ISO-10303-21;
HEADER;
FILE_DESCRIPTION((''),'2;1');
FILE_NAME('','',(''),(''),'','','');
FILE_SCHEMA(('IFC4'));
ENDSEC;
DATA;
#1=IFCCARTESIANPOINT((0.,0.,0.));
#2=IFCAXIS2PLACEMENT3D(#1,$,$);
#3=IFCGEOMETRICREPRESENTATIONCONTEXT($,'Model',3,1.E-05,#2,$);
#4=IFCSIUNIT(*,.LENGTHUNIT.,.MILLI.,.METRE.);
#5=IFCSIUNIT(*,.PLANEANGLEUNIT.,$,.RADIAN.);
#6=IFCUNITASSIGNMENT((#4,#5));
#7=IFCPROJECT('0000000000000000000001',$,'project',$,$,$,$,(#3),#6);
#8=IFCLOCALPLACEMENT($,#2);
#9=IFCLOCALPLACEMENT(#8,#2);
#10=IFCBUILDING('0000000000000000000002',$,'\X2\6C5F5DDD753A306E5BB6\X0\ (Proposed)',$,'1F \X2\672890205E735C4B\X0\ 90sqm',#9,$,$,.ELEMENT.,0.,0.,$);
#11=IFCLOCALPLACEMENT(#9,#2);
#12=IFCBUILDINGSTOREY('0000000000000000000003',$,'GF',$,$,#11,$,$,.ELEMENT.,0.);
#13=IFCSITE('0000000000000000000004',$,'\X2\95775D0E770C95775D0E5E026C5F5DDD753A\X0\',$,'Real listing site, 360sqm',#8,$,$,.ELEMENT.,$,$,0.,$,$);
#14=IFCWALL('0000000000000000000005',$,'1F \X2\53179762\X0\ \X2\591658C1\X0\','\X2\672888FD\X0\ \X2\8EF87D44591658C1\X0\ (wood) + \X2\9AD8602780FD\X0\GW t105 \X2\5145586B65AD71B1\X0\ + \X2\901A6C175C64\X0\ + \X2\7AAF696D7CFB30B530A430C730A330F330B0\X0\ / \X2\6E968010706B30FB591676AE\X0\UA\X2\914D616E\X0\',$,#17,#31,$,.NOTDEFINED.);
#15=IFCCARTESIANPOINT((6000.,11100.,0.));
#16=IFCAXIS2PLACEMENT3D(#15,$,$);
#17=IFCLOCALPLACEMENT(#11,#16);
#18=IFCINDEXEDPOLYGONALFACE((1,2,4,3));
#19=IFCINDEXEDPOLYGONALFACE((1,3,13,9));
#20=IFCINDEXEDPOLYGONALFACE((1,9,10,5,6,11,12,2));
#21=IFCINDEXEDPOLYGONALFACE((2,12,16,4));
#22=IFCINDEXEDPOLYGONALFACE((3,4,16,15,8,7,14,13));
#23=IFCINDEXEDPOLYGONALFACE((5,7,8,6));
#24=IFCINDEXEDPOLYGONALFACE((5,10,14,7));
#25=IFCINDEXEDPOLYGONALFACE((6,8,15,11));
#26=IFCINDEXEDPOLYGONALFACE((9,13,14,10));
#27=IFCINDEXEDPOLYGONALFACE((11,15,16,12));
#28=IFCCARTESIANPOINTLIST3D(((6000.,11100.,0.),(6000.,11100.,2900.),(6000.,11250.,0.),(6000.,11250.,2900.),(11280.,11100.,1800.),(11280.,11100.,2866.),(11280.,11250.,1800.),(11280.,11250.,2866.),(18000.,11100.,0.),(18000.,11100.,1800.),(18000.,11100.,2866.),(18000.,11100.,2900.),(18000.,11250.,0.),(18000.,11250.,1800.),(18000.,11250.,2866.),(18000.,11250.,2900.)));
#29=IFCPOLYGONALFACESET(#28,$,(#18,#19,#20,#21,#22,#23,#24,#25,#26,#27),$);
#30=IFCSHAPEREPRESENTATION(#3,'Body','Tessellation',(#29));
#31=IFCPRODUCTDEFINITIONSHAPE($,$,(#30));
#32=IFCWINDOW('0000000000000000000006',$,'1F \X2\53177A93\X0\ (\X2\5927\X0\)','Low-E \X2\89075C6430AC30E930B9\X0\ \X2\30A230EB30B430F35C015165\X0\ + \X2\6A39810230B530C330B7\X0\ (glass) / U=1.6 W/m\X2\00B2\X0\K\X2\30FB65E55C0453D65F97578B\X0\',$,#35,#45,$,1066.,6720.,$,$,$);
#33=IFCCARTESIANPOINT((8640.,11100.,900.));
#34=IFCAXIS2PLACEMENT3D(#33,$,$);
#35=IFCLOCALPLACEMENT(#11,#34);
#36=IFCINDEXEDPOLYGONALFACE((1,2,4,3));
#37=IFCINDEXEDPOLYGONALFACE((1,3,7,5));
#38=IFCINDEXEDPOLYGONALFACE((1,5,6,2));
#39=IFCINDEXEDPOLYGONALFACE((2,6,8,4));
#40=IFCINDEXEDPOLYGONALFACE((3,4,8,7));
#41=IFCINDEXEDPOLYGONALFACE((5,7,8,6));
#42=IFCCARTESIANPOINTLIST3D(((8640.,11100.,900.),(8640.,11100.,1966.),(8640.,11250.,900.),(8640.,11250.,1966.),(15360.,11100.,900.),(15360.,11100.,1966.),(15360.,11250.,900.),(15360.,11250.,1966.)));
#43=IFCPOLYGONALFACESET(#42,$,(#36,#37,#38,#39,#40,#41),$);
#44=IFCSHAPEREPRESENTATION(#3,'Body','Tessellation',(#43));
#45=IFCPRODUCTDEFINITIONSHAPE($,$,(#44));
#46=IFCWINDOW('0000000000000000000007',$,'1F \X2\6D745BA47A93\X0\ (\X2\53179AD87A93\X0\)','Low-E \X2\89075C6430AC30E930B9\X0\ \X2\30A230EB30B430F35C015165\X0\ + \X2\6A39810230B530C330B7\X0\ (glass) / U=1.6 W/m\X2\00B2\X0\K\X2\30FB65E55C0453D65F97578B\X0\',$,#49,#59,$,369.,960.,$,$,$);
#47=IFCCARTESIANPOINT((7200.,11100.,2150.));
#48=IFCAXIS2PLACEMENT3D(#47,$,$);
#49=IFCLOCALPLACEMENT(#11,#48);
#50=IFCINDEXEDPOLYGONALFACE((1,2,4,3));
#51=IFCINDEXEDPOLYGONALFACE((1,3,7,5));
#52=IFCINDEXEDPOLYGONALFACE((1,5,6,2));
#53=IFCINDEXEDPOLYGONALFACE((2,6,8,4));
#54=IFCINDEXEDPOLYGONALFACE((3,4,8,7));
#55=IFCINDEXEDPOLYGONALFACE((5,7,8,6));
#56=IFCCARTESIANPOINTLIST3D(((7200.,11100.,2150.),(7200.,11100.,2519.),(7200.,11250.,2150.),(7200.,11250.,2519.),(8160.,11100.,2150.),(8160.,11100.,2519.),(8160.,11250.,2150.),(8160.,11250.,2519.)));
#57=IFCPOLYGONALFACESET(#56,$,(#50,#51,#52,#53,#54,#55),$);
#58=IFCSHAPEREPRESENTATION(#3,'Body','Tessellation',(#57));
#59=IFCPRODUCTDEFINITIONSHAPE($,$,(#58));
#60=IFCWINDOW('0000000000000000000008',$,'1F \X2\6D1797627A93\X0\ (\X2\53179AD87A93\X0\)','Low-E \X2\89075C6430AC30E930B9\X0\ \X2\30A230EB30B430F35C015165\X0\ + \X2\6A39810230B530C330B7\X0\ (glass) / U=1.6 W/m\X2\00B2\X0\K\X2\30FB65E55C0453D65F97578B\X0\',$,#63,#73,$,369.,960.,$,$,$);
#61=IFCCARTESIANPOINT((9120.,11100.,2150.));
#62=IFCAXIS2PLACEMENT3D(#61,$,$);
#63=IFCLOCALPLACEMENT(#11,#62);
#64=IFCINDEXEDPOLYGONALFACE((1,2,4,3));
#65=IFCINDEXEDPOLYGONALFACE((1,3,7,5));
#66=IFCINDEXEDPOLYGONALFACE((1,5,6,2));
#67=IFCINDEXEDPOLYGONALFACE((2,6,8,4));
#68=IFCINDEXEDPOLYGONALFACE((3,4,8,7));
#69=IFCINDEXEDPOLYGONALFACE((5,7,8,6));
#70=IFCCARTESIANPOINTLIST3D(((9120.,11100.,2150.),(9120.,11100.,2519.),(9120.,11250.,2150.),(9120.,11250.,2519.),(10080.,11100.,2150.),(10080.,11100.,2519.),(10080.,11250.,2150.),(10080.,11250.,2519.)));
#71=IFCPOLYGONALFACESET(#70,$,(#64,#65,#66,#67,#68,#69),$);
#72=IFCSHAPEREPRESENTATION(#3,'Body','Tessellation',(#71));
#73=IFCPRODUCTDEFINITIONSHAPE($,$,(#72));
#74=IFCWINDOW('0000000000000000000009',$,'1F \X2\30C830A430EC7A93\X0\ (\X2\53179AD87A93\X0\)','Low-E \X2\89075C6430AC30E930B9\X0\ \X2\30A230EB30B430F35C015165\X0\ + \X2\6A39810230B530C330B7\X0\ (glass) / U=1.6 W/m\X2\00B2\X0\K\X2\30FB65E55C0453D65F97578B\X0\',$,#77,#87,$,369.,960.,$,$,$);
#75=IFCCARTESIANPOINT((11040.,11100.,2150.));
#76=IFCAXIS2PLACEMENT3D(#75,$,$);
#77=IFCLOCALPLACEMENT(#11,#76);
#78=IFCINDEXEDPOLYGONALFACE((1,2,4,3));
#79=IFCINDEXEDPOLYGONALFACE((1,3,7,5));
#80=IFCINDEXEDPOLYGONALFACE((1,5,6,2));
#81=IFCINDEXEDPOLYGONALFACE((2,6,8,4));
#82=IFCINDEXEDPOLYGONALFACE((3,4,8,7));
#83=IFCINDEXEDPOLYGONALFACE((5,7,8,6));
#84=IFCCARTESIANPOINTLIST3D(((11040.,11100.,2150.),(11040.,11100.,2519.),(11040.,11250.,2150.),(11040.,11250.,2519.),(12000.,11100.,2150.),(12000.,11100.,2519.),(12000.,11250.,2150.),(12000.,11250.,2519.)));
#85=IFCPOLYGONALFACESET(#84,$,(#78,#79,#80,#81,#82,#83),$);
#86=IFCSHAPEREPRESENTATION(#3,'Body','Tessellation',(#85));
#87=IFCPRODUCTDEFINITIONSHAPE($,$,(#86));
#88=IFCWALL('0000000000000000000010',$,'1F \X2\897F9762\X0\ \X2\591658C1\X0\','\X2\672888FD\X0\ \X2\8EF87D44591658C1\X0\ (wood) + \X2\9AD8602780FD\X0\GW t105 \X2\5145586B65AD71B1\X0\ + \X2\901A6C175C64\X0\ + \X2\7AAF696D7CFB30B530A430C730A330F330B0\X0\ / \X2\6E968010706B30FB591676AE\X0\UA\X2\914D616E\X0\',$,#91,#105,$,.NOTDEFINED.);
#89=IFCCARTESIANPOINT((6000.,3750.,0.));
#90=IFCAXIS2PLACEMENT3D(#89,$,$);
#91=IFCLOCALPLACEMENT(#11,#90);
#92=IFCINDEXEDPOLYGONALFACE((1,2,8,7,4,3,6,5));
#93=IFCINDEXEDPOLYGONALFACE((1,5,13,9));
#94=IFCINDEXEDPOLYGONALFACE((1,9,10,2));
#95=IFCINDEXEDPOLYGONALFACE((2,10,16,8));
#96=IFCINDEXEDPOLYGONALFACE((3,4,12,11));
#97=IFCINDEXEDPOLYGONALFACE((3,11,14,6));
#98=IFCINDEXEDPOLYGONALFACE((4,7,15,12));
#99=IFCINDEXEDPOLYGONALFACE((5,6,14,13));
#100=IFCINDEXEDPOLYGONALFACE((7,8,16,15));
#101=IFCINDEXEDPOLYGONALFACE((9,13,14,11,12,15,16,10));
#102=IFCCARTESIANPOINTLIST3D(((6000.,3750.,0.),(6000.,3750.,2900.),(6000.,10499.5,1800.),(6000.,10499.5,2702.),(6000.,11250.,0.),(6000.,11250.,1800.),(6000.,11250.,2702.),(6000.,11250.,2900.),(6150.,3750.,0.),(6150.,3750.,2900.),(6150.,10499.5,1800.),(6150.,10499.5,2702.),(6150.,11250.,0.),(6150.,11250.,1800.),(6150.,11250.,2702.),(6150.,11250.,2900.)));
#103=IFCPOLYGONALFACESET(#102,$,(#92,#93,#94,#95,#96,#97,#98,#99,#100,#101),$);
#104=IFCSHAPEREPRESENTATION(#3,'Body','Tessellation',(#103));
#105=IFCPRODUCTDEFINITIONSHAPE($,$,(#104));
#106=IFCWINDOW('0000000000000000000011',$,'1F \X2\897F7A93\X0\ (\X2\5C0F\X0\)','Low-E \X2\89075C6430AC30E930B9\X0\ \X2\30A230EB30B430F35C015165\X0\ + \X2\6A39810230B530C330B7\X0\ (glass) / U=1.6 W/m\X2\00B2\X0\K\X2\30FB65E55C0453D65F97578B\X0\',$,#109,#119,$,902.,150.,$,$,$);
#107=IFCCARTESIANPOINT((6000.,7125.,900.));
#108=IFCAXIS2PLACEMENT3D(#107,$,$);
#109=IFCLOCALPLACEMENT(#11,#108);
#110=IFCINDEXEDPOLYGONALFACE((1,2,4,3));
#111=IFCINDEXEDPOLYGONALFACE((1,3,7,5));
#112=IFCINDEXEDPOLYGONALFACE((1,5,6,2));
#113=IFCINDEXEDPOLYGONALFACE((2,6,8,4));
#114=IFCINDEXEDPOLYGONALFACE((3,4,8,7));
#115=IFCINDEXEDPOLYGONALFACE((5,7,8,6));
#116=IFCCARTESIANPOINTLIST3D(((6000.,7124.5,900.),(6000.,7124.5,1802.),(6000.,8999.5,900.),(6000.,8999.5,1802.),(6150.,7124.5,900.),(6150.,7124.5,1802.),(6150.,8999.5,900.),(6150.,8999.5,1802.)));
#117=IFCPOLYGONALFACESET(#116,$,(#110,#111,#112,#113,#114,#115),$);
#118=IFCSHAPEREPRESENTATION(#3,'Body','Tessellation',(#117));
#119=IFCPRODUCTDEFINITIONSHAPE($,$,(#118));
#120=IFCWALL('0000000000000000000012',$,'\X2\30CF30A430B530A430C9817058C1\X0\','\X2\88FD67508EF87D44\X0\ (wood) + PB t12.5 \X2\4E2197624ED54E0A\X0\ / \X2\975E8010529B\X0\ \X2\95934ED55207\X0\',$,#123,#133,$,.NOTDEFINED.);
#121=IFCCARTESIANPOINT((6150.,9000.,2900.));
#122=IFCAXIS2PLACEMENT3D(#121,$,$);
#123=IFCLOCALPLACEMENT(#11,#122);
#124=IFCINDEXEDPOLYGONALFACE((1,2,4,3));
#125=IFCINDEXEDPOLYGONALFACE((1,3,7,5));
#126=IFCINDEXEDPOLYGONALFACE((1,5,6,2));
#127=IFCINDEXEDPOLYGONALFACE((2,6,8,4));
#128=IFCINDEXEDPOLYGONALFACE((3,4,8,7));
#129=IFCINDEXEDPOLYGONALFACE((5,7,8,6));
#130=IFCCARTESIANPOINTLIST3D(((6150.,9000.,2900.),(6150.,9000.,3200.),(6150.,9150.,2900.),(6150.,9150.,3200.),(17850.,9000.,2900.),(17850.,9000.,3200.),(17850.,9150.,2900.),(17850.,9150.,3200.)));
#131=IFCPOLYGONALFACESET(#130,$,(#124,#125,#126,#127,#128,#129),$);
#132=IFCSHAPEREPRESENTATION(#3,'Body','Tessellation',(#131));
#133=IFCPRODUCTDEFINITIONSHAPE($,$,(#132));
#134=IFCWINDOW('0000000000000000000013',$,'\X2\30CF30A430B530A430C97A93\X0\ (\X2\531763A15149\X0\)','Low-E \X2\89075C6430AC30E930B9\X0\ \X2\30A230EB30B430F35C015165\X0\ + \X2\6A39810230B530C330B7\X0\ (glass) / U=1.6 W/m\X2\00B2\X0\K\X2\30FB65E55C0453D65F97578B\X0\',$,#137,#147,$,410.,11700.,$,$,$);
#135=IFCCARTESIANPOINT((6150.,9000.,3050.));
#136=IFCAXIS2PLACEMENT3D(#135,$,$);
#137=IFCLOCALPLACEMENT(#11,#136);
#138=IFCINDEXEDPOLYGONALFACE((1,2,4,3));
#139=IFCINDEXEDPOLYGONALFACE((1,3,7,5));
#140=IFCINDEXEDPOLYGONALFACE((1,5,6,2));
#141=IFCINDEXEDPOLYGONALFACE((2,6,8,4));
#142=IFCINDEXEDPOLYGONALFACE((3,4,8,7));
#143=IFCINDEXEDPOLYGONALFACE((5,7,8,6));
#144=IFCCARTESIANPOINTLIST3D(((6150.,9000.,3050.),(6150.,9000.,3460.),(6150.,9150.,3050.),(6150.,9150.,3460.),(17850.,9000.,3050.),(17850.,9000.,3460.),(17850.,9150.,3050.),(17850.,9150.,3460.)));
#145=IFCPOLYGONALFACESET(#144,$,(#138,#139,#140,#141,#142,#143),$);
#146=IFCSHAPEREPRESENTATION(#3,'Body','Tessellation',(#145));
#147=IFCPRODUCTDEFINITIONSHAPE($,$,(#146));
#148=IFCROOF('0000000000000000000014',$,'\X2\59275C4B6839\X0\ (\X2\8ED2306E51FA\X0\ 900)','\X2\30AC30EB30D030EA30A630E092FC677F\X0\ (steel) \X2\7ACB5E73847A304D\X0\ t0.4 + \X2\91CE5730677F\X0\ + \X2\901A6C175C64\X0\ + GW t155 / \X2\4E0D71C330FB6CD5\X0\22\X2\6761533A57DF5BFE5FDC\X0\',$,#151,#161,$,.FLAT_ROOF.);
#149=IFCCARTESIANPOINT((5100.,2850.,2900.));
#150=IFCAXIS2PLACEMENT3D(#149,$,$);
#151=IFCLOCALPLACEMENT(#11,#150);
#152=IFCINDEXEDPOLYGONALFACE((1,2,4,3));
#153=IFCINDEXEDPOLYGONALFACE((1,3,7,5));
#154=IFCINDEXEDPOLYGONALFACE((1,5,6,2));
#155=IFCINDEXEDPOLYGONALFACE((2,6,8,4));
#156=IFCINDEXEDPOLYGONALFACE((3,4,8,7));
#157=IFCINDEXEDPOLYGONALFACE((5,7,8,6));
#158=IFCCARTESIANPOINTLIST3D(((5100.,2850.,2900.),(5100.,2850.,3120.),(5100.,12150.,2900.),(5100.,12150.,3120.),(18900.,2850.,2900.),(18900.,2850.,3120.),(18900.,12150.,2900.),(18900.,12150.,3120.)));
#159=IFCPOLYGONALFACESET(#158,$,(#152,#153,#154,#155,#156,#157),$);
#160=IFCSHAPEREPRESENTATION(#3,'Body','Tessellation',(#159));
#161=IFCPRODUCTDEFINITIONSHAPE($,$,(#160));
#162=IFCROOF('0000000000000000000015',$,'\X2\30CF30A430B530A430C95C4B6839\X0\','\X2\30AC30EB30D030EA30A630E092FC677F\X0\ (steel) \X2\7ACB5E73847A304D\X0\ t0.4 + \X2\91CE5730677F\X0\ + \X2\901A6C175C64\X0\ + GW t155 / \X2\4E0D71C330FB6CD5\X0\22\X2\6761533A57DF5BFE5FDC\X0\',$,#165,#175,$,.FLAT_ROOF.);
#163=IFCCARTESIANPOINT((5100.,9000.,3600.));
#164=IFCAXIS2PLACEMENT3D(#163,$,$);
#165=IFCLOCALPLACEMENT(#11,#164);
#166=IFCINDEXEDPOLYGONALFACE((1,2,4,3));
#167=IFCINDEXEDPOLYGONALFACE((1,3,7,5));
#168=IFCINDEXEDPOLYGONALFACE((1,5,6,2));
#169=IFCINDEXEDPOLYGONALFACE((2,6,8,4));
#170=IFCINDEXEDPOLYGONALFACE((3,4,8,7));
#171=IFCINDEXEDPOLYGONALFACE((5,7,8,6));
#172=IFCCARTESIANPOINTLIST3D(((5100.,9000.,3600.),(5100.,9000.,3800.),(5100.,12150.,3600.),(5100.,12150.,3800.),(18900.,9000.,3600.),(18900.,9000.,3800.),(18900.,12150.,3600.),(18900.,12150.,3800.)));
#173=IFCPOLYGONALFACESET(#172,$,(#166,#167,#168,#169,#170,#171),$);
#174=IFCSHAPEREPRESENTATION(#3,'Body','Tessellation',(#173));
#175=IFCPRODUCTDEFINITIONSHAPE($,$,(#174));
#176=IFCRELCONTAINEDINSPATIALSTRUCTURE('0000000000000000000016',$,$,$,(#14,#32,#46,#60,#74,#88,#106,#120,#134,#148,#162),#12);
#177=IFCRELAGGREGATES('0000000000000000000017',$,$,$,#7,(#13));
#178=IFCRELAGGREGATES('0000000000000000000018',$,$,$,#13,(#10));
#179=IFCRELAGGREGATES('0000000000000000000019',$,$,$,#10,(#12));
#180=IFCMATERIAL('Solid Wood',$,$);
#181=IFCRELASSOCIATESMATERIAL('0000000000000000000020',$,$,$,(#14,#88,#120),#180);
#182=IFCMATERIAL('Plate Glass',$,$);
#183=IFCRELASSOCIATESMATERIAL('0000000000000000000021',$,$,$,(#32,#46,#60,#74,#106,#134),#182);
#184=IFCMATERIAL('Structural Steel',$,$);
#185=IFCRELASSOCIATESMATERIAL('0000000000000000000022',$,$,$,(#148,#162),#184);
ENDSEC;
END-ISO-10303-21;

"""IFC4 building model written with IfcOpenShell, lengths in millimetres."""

from ifc_helpers import new_model, si_unit, frame, frame_2d, origin, place, context, project, spatial, rectangle, extrude, material, element, fill, save


model = new_model("IFC4")

# Units and contexts
model_context = context("Model", 3, precision=1e-05, world=origin())
ifc_project = project(units=[si_unit("LENGTHUNIT", "METRE", prefix="MILLI"), si_unit("PLANEANGLEUNIT", "RADIAN")], contexts=[model_context])

# Site, building, storey
site_placement = place(None, origin())
site = spatial("IfcSite", under=ifc_project, at=site_placement, Name="長崎県長崎市江川町", ObjectType="Real listing site, 360sqm", CompositionType="ELEMENT", RefElevation=0.0)
building_placement = place(site_placement, origin())
building = spatial("IfcBuilding", under=site, at=building_placement, Name="江川町の家 (Proposed)", ObjectType="1F 木造平屋 90sqm", CompositionType="ELEMENT", ElevationOfRefHeight=0.0, ElevationOfTerrain=0.0)
storey_placement = place(building_placement, origin())
storey = spatial("IfcBuildingStorey", under=building, at=storey_placement, Name="GF", CompositionType="ELEMENT", Elevation=0.0)

# Shared definitions
ifc_material_1 = material(Name="Solid Wood")

# Shared definitions
ifc_material_2 = material(Name="Plate Glass")

# Wall, openings, windows
wall_1_placement = place(storey_placement, frame((6000.0, 11100.0, 0.0)))
wall_1 = element("IfcWall", 1, at=wall_1_placement, inside=storey, material=ifc_material_1, Name="1F 北面 外壁", Description="木製 軸組外壁 (wood) + 高性能GW t105 充填断熱 + 通気層 + 窯業系サイディング / 準耐火・外皮UA配慮", PredefinedType="NOTDEFINED", context=model_context, shape_type="SweptSolid", body=[
    extrude(rectangle(XDim=12000.0, YDim=150.0, at=frame_2d((6000.0, 75.0))), frame((6000.0, 11100.0, 0.0)), (0.0, 0.0, 1.0), 2900.0),
])
opening_1_placement = place(storey_placement, frame((8640.0, 11100.0, 900.0)))
opening_1 = element("IfcOpeningElement", 2, at=opening_1_placement, cuts=wall_1, PredefinedType="NOTDEFINED", context=model_context, shape_type="SweptSolid", body=[
    extrude(rectangle(XDim=6720.0, YDim=150.0, at=frame_2d((3360.0, 75.0))), frame((8640.0, 11100.0, 900.0)), (0.0, 0.0, 1.0), 1066.0),
])
opening_2_placement = place(storey_placement, frame((7200.0, 11100.0, 2150.0)))
opening_2 = element("IfcOpeningElement", 3, at=opening_2_placement, cuts=wall_1, PredefinedType="NOTDEFINED", context=model_context, shape_type="SweptSolid", body=[
    extrude(rectangle(XDim=960.0, YDim=150.0, at=frame_2d((480.0, 75.0))), frame((7200.0, 11100.0, 2150.0)), (0.0, 0.0, 1.0), 369.0),
])
opening_3_placement = place(storey_placement, frame((9120.0, 11100.0, 2150.0)))
opening_3 = element("IfcOpeningElement", 4, at=opening_3_placement, cuts=wall_1, PredefinedType="NOTDEFINED", context=model_context, shape_type="SweptSolid", body=[
    extrude(rectangle(XDim=960.0, YDim=150.0, at=frame_2d((480.0, 75.0))), frame((9120.0, 11100.0, 2150.0)), (0.0, 0.0, 1.0), 369.0),
])
opening_4_placement = place(storey_placement, frame((11040.0, 11100.0, 2150.0)))
opening_4 = element("IfcOpeningElement", 5, at=opening_4_placement, cuts=wall_1, PredefinedType="NOTDEFINED", context=model_context, shape_type="SweptSolid", body=[
    extrude(rectangle(XDim=960.0, YDim=150.0, at=frame_2d((480.0, 75.0))), frame((11040.0, 11100.0, 2150.0)), (0.0, 0.0, 1.0), 369.0),
])
window_1_placement = place(storey_placement, frame((8640.0, 11100.0, 900.0)))
window_1 = element("IfcWindow", 6, at=window_1_placement, inside=storey, material=ifc_material_2, Name="1F 北窓 (大)", Description="Low-E 複層ガラス アルゴン封入 + 樹脂サッシ (glass) / U=1.6 W/m²K・日射取得型", OverallHeight=1066.0, OverallWidth=6720.0, context=model_context, shape_type="SweptSolid", body=[
    extrude(rectangle(XDim=6720.0, YDim=150.0, at=frame_2d((3360.0, 75.0))), frame((8640.0, 11100.0, 900.0)), (0.0, 0.0, 1.0), 1066.0),
])
fill(opening_1, window_1)
window_2_placement = place(storey_placement, frame((7200.0, 11100.0, 2150.0)))
window_2 = element("IfcWindow", 7, at=window_2_placement, inside=storey, material=ifc_material_2, Name="1F 浴室窓 (北高窓)", Description="Low-E 複層ガラス アルゴン封入 + 樹脂サッシ (glass) / U=1.6 W/m²K・日射取得型", OverallHeight=369.0, OverallWidth=960.0, context=model_context, shape_type="SweptSolid", body=[
    extrude(rectangle(XDim=960.0, YDim=150.0, at=frame_2d((480.0, 75.0))), frame((7200.0, 11100.0, 2150.0)), (0.0, 0.0, 1.0), 369.0),
])
fill(opening_2, window_2)
window_3_placement = place(storey_placement, frame((9120.0, 11100.0, 2150.0)))
window_3 = element("IfcWindow", 8, at=window_3_placement, inside=storey, material=ifc_material_2, Name="1F 洗面窓 (北高窓)", Description="Low-E 複層ガラス アルゴン封入 + 樹脂サッシ (glass) / U=1.6 W/m²K・日射取得型", OverallHeight=369.0, OverallWidth=960.0, context=model_context, shape_type="SweptSolid", body=[
    extrude(rectangle(XDim=960.0, YDim=150.0, at=frame_2d((480.0, 75.0))), frame((9120.0, 11100.0, 2150.0)), (0.0, 0.0, 1.0), 369.0),
])
fill(opening_3, window_3)
window_4_placement = place(storey_placement, frame((11040.0, 11100.0, 2150.0)))
window_4 = element("IfcWindow", 9, at=window_4_placement, inside=storey, material=ifc_material_2, Name="1F トイレ窓 (北高窓)", Description="Low-E 複層ガラス アルゴン封入 + 樹脂サッシ (glass) / U=1.6 W/m²K・日射取得型", OverallHeight=369.0, OverallWidth=960.0, context=model_context, shape_type="SweptSolid", body=[
    extrude(rectangle(XDim=960.0, YDim=150.0, at=frame_2d((480.0, 75.0))), frame((11040.0, 11100.0, 2150.0)), (0.0, 0.0, 1.0), 369.0),
])
fill(opening_4, window_4)

# Wall, opening, window
wall_2_placement = place(storey_placement, frame((6000.0, 3750.0, 0.0)))
wall_2 = element("IfcWall", 10, at=wall_2_placement, inside=storey, material=ifc_material_1, Name="1F 西面 外壁", Description="木製 軸組外壁 (wood) + 高性能GW t105 充填断熱 + 通気層 + 窯業系サイディング / 準耐火・外皮UA配慮", PredefinedType="NOTDEFINED", context=model_context, shape_type="SweptSolid", body=[
    extrude(rectangle(XDim=150.0, YDim=7500.0, at=frame_2d((75.0, 3750.0))), frame((6000.0, 3750.0, 0.0)), (0.0, 0.0, 1.0), 2900.0),
])
opening_5_placement = place(storey_placement, frame((6000.0, 7125.0, 900.0)))
opening_5 = element("IfcOpeningElement", 11, at=opening_5_placement, cuts=wall_2, PredefinedType="NOTDEFINED", context=model_context, shape_type="SweptSolid", body=[
    extrude(rectangle(XDim=150.0, YDim=1875.0, at=frame_2d((75.0, 937.0))), frame((6000.0, 7125.0, 900.0)), (0.0, 0.0, 1.0), 902.0),
])
window_5_placement = place(storey_placement, frame((6000.0, 7125.0, 900.0)))
window_5 = element("IfcWindow", 12, at=window_5_placement, inside=storey, material=ifc_material_2, Name="1F 西窓 (小)", Description="Low-E 複層ガラス アルゴン封入 + 樹脂サッシ (glass) / U=1.6 W/m²K・日射取得型", OverallHeight=902.0, OverallWidth=150.0, context=model_context, shape_type="SweptSolid", body=[
    extrude(rectangle(XDim=150.0, YDim=1875.0, at=frame_2d((75.0, 937.0))), frame((6000.0, 7125.0, 900.0)), (0.0, 0.0, 1.0), 902.0),
])
fill(opening_5, window_5)

# Wall, opening, window
wall_3_placement = place(storey_placement, frame((6150.0, 9000.0, 2900.0)))
wall_3 = element("IfcWall", 13, at=wall_3_placement, inside=storey, material=ifc_material_1, Name="ハイサイド腰壁", Description="製材軸組 (wood) + PB t12.5 両面仕上 / 非耐力 間仕切", PredefinedType="NOTDEFINED", context=model_context, shape_type="SweptSolid", body=[
    extrude(rectangle(XDim=11700.0, YDim=150.0, at=frame_2d((5850.0, 75.0))), frame((6150.0, 9000.0, 2900.0)), (0.0, 0.0, 1.0), 700.0),
])
opening_6_placement = place(storey_placement, frame((6150.0, 9000.0, 3050.0)))
opening_6 = element("IfcOpeningElement", 14, at=opening_6_placement, cuts=wall_3, PredefinedType="NOTDEFINED", context=model_context, shape_type="SweptSolid", body=[
    extrude(rectangle(XDim=11700.0, YDim=150.0, at=frame_2d((5850.0, 75.0))), frame((6150.0, 9000.0, 3050.0)), (0.0, 0.0, 1.0), 410.0),
])
window_6_placement = place(storey_placement, frame((6150.0, 9000.0, 3050.0)))
window_6 = element("IfcWindow", 15, at=window_6_placement, inside=storey, material=ifc_material_2, Name="ハイサイド窓 (北採光)", Description="Low-E 複層ガラス アルゴン封入 + 樹脂サッシ (glass) / U=1.6 W/m²K・日射取得型", OverallHeight=410.0, OverallWidth=11700.0, context=model_context, shape_type="SweptSolid", body=[
    extrude(rectangle(XDim=11700.0, YDim=150.0, at=frame_2d((5850.0, 75.0))), frame((6150.0, 9000.0, 3050.0)), (0.0, 0.0, 1.0), 410.0),
])
fill(opening_6, window_6)

# Roofs
ifc_material_3 = material(Name="Structural Steel")
roof_1_placement = place(storey_placement, frame((5100.0, 2850.0, 2900.0)))
element("IfcRoof", 16, at=roof_1_placement, inside=storey, material=ifc_material_3, Name="大屋根 (軒の出 900)", Description="ガルバリウム鋼板 (steel) 立平葺き t0.4 + 野地板 + 通気層 + GW t155 / 不燃・法22条区域対応", PredefinedType="FLAT_ROOF", context=model_context, shape_type="SweptSolid", body=[
    extrude(rectangle(XDim=13800.0, YDim=9300.0, at=frame_2d((6900.0, 4650.0))), frame((5100.0, 2850.0, 2900.0)), (0.0, 0.0, 1.0), 220.0),
])
roof_2_placement = place(storey_placement, frame((5100.0, 9000.0, 3600.0)))
element("IfcRoof", 17, at=roof_2_placement, inside=storey, material=ifc_material_3, Name="ハイサイド屋根", Description="ガルバリウム鋼板 (steel) 立平葺き t0.4 + 野地板 + 通気層 + GW t155 / 不燃・法22条区域対応", PredefinedType="FLAT_ROOF", context=model_context, shape_type="SweptSolid", body=[
    extrude(rectangle(XDim=13800.0, YDim=3150.0, at=frame_2d((6900.0, 1575.0))), frame((5100.0, 9000.0, 3600.0)), (0.0, 0.0, 1.0), 200.0),
])

save(model, "model.ifc")
